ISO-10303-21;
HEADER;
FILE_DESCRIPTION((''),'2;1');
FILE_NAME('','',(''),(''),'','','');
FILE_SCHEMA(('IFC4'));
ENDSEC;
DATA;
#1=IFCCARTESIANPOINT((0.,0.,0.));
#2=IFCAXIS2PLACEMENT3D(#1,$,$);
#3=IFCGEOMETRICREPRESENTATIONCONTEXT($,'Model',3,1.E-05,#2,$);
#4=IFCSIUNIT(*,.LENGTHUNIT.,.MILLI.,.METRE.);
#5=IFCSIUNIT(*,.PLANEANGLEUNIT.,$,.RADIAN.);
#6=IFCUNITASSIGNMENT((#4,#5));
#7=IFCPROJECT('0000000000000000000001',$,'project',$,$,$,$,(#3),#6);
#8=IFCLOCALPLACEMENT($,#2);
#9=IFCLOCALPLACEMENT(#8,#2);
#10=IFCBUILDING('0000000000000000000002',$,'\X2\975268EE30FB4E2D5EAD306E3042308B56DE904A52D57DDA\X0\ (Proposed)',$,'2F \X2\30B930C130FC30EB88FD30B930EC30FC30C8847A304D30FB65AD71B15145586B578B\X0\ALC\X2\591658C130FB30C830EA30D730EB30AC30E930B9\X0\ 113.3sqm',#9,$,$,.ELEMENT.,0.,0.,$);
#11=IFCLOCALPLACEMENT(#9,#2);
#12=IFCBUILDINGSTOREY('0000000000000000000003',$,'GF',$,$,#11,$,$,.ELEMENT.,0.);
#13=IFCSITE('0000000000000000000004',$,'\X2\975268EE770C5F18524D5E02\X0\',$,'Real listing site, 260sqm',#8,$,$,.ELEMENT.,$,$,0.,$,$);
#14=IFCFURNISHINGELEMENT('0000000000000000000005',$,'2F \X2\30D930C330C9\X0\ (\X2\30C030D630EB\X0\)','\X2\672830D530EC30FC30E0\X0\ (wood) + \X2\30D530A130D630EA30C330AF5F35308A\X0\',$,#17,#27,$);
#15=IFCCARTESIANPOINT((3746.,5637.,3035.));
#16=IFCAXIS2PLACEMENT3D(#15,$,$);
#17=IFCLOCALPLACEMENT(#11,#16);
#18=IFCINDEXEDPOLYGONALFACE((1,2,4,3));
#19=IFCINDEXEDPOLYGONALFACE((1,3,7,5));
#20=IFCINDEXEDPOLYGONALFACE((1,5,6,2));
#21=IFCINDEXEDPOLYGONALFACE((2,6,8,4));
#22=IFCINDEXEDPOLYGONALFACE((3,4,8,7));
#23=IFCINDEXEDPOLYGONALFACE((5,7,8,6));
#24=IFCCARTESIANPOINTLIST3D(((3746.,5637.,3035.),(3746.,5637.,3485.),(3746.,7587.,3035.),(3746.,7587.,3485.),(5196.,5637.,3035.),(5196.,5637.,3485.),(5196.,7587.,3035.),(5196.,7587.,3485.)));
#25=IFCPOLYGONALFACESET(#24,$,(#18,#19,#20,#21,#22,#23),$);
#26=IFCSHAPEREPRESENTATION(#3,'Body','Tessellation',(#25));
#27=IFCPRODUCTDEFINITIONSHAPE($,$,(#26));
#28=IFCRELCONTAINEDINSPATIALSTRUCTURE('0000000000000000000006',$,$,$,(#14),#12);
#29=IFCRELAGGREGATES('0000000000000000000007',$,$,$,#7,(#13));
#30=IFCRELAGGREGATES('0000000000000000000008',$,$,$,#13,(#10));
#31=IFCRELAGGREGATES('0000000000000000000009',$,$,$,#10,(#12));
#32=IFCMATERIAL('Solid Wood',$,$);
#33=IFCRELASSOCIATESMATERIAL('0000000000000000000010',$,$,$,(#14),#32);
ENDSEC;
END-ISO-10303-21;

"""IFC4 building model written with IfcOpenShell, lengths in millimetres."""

from ifc_helpers import new_model, si_unit, frame, frame_2d, origin, place, context, project, spatial, rectangle, extrude, material, element, save


model = new_model("IFC4")

# Units and contexts
model_context = context("Model", 3, precision=1e-05, world=origin())
ifc_project = project(units=[si_unit("LENGTHUNIT", "METRE", prefix="MILLI"), si_unit("PLANEANGLEUNIT", "RADIAN")], contexts=[model_context])

# Site, building, storey
site_placement = place(None, origin())
site = spatial("IfcSite", under=ifc_project, at=site_placement, Name="青森県弘前市", ObjectType="Real listing site, 260sqm", CompositionType="ELEMENT", RefElevation=0.0)
building_placement = place(site_placement, origin())
building = spatial("IfcBuilding", under=site, at=building_placement, Name="青森・中庭のある回遊動線 (Proposed)", ObjectType="2F スチール製スレート葺き・断熱充填型ALC外壁・トリプルガラス 113.3sqm", CompositionType="ELEMENT", ElevationOfRefHeight=0.0, ElevationOfTerrain=0.0)
storey_placement = place(building_placement, origin())
storey = spatial("IfcBuildingStorey", under=building, at=storey_placement, Name="GF", CompositionType="ELEMENT", Elevation=0.0)

# Shared definitions
ifc_material_1 = material(Name="Solid Wood")

# Furnishing element
furnishing_1_placement = place(storey_placement, frame((3746.0, 5637.0, 3035.0)))
element("IfcFurnishingElement", 1, at=furnishing_1_placement, inside=storey, material=ifc_material_1, Name="2F ベッド (ダブル)", Description="木フレーム (wood) + ファブリック張り", context=model_context, shape_type="SweptSolid", body=[
    extrude(rectangle(XDim=1450.0, YDim=1950.0, at=frame_2d((725.0, 975.0))), frame((3746.0, 5637.0, 3035.0)), (0.0, 0.0, 1.0), 450.0),
])

save(model, "model.ifc")
